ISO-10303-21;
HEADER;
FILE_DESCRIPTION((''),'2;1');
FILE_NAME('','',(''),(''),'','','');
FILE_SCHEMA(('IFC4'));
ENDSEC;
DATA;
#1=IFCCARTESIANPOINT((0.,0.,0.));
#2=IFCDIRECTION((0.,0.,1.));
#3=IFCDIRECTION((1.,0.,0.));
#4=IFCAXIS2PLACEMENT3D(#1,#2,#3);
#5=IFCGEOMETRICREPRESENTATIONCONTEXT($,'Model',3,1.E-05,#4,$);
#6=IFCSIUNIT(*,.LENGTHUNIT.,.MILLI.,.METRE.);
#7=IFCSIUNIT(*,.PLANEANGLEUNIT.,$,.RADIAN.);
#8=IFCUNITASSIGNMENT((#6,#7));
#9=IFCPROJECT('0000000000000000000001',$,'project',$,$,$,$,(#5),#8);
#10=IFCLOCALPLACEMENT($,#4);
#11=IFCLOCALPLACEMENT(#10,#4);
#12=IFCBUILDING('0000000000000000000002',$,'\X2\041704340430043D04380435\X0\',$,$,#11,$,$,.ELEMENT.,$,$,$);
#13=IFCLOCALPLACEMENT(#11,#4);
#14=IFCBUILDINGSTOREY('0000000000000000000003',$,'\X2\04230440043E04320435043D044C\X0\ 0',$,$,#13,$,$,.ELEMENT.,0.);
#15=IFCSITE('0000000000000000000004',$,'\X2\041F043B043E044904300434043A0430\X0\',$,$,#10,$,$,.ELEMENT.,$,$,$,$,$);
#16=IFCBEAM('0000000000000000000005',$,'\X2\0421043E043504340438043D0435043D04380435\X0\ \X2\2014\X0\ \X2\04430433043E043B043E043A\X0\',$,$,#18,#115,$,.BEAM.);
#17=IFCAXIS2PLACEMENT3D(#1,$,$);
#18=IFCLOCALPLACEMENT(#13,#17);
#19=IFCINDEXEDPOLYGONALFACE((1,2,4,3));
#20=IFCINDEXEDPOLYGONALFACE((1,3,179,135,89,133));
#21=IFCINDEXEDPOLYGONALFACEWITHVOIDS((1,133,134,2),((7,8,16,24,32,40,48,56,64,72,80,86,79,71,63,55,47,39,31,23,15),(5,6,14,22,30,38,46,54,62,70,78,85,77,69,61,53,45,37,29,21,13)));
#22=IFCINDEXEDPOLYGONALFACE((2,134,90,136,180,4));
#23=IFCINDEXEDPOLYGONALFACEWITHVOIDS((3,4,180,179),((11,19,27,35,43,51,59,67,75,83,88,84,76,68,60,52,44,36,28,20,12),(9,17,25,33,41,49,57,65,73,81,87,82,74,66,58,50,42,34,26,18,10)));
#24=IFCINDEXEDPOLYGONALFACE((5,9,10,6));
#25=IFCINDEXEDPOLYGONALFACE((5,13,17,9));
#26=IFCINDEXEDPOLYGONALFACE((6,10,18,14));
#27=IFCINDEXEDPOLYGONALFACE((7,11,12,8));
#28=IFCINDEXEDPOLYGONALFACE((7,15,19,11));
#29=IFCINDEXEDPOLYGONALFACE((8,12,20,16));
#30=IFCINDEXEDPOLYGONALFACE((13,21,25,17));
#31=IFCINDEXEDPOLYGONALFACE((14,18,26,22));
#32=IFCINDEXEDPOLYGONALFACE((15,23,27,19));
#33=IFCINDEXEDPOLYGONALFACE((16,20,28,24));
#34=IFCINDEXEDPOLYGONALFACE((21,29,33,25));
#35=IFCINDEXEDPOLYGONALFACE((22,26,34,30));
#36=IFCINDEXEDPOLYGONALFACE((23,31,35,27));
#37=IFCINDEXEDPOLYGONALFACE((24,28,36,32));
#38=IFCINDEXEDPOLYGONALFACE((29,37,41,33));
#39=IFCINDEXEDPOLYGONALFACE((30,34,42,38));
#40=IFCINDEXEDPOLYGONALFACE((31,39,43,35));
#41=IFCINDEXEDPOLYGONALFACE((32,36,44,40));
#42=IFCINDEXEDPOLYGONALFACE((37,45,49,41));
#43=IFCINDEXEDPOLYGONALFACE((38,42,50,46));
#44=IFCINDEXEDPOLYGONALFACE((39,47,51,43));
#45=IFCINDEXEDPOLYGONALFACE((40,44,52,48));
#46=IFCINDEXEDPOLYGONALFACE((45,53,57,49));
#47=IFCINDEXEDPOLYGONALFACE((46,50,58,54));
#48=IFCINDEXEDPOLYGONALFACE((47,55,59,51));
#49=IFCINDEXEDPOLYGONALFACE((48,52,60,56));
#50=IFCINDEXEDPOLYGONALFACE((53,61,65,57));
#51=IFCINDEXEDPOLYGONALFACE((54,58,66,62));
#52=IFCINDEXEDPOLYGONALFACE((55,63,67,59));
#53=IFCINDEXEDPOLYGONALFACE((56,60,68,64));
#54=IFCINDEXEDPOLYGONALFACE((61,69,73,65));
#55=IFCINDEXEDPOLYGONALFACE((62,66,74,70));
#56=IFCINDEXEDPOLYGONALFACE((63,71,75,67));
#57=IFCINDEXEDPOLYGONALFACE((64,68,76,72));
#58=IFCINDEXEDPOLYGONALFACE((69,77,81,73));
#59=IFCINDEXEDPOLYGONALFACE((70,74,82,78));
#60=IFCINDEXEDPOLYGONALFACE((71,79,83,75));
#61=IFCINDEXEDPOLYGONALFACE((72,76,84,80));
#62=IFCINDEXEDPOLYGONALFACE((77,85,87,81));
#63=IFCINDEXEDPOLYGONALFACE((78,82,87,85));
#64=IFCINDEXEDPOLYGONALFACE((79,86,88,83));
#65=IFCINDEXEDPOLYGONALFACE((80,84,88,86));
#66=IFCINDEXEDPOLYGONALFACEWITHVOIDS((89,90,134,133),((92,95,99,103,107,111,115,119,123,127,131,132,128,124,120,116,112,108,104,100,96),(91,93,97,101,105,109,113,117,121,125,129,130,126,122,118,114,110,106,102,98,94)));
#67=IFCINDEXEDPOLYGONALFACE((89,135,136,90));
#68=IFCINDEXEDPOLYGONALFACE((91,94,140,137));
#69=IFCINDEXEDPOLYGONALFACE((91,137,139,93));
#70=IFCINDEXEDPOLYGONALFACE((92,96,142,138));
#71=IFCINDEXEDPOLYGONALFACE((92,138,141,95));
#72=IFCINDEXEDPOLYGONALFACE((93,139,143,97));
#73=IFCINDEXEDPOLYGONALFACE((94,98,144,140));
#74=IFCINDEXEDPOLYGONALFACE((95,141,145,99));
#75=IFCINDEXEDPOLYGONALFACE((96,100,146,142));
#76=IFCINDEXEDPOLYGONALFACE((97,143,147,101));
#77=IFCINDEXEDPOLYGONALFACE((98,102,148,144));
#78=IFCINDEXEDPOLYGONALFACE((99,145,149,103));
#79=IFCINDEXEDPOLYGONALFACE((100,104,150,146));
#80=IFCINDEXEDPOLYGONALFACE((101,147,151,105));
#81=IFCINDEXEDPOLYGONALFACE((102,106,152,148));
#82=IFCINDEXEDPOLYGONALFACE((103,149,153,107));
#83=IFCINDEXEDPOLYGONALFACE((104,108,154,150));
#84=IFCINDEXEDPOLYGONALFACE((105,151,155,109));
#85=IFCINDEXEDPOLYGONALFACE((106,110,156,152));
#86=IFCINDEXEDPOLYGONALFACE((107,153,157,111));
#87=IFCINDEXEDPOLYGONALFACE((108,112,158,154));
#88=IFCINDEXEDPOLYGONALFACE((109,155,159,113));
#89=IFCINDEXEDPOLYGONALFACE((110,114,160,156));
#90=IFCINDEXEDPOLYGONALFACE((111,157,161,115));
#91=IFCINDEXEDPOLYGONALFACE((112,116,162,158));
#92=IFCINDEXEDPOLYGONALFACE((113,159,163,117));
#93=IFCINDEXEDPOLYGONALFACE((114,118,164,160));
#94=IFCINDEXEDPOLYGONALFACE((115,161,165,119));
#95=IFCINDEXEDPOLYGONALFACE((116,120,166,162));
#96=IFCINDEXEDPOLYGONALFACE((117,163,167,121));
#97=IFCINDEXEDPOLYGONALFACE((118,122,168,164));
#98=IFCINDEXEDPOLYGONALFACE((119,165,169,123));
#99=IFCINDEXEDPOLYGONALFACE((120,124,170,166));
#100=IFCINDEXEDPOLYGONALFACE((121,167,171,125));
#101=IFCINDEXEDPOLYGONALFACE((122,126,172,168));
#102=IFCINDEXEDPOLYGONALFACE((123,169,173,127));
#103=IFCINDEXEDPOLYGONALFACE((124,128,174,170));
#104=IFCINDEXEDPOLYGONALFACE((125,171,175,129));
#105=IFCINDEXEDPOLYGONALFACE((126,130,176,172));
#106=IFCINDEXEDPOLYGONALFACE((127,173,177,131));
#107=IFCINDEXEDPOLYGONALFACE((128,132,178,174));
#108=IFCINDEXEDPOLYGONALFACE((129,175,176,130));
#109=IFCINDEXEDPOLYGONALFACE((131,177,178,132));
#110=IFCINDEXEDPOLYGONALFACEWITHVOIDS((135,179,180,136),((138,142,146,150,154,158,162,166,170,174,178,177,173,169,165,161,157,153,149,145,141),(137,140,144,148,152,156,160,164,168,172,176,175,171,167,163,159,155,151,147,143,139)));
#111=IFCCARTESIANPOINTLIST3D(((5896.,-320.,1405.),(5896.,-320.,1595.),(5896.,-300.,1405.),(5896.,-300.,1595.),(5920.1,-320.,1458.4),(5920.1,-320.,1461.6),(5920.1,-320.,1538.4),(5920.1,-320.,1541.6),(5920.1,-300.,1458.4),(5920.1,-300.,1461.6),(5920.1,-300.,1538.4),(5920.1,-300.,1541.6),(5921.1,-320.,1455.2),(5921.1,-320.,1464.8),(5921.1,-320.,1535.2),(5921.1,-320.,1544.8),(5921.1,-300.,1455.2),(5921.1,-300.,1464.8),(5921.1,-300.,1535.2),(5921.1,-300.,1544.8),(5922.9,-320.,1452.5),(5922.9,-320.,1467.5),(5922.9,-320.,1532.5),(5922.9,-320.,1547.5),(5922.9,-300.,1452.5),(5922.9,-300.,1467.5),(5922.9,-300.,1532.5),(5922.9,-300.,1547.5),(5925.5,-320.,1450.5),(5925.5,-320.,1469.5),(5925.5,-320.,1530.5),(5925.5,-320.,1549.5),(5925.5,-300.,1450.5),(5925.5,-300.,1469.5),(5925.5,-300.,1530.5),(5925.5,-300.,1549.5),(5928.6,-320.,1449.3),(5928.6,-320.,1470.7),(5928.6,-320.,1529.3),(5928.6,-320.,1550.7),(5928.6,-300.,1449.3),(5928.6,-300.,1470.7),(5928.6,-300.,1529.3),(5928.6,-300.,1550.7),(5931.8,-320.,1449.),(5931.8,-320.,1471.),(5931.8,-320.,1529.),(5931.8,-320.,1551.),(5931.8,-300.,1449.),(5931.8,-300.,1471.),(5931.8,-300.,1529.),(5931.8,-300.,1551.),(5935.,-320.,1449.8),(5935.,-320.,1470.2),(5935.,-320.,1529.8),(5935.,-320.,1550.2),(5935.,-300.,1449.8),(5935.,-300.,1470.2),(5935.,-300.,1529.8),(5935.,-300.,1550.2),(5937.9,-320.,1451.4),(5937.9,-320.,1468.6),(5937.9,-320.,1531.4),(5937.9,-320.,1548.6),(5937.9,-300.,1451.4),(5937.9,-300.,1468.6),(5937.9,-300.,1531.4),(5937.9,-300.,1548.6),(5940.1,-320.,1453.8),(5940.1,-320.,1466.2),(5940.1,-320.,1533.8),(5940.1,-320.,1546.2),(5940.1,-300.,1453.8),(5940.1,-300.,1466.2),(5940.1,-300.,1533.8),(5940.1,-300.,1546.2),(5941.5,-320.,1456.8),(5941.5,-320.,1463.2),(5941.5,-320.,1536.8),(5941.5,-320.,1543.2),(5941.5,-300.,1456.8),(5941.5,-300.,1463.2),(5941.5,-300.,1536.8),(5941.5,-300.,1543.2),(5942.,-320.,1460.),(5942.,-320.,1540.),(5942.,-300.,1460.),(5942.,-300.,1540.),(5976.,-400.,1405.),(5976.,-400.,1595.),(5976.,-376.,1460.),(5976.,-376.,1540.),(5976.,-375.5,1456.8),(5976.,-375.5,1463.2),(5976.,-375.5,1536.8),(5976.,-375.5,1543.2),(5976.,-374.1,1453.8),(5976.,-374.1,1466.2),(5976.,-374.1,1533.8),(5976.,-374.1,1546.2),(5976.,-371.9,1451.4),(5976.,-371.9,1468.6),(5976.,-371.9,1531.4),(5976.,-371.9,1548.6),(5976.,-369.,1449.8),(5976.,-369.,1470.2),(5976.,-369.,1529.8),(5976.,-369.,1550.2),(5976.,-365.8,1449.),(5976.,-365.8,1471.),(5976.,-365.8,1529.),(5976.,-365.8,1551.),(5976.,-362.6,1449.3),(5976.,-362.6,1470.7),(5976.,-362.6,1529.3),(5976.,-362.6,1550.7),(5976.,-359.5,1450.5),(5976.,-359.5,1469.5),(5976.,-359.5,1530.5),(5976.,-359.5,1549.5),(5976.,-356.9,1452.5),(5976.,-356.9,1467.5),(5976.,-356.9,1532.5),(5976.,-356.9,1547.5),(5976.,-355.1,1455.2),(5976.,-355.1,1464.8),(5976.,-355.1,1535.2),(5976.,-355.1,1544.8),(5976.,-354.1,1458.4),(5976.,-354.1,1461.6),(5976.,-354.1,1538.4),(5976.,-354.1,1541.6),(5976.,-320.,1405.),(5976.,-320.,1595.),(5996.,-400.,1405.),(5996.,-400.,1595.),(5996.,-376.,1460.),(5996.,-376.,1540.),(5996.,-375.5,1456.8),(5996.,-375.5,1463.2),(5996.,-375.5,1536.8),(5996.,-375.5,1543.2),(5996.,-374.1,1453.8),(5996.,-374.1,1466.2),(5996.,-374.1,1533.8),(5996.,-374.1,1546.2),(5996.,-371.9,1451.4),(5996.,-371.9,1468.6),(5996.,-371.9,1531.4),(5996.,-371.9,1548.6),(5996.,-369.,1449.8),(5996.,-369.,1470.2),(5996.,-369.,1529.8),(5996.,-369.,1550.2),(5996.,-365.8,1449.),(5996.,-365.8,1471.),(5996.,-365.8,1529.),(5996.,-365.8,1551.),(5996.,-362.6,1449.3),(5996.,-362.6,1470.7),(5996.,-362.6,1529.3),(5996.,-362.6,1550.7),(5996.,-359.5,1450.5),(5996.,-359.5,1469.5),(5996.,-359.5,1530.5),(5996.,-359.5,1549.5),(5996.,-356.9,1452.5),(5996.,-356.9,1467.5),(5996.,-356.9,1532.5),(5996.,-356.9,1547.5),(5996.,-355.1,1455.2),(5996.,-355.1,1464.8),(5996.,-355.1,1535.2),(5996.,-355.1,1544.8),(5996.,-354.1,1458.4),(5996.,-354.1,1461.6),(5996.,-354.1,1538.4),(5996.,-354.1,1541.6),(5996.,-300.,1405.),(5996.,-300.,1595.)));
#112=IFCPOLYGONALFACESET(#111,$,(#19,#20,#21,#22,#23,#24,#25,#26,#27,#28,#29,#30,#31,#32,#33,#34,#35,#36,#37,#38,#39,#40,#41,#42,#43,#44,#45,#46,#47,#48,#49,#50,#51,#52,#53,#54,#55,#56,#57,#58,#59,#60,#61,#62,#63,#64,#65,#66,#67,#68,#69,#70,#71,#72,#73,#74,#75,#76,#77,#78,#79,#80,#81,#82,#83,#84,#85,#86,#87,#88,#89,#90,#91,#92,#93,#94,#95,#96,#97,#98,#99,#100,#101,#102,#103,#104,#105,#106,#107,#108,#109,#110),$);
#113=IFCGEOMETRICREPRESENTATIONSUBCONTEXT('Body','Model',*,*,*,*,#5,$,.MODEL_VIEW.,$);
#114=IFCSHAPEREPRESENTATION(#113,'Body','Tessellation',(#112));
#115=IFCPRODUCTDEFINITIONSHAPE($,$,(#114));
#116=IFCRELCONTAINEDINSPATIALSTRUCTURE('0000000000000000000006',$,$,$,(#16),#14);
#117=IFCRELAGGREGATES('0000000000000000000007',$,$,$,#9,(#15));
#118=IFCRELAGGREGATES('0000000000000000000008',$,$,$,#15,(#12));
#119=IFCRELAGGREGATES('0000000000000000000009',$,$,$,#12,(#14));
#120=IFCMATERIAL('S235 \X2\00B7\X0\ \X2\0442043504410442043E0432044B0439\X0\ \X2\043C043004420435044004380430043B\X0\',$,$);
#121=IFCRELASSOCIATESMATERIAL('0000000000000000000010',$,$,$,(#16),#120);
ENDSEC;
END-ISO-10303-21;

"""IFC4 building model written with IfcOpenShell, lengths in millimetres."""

from ifc_helpers import new_model, si_unit, frame, origin_with_axes, place, context, subcontext, project, spatial, circle, l_section, extrude, material, element, save


model = new_model("IFC4")

# Units and contexts
model_context = context("Model", 3, precision=1e-05, world=origin_with_axes())
body_context = subcontext(model_context, "Body", "Model", "MODEL_VIEW")
ifc_project = project(units=[si_unit("LENGTHUNIT", "METRE", prefix="MILLI"), si_unit("PLANEANGLEUNIT", "RADIAN")], contexts=[model_context])

# Site, building, storey
site_placement = place(None, origin_with_axes())
site = spatial("IfcSite", under=ifc_project, at=site_placement, Name="Площадка", CompositionType="ELEMENT")
building_placement = place(site_placement, origin_with_axes())
building = spatial("IfcBuilding", under=site, at=building_placement, Name="Здание", CompositionType="ELEMENT")
storey_placement = place(building_placement, origin_with_axes())
storey = spatial("IfcBuildingStorey", under=building, at=storey_placement, Name="Уровень 0", CompositionType="ELEMENT", Elevation=0.0)

# Shared definitions
ifc_material = material(Name="S235 · тестовый материал")

# Beam, openings
beam_1_placement = place(storey_placement, frame((5946.0, -350.0, 1595.0), z_axis=(0.0, 0.0, -1.0), x_axis=(0.0, -1.0, 0.0)))
beam_1 = element("IfcBeam", 1, at=beam_1_placement, inside=storey, material=ifc_material, Name="Соединение — уголок", PredefinedType="BEAM", context=body_context, shape_type="SweptSolid", body=[
    extrude(l_section(Depth=100.0, Width=100.0, Thickness=20.0), origin_with_axes(), (0.0, 0.0, 1.0), 190.0),
])
opening_1_placement = place(beam_1_placement, frame((15.0, -29.0, 55.0), z_axis=(0.0, -1.0, 0.0), x_axis=(1.0, 0.0, 0.0)))
element("IfcOpeningElement", 2, at=opening_1_placement, cuts=beam_1, PredefinedType="OPENING", context=body_context, shape_type="SweptSolid", body=[
    extrude(circle(Radius=11.0), origin_with_axes(), (0.0, 0.0, 1.0), 30.0),
])
opening_2_placement = place(beam_1_placement, frame((15.0, -29.0, 135.0), z_axis=(0.0, -1.0, 0.0), x_axis=(1.0, 0.0, 0.0)))
element("IfcOpeningElement", 3, at=opening_2_placement, cuts=beam_1, PredefinedType="OPENING", context=body_context, shape_type="SweptSolid", body=[
    extrude(circle(Radius=11.0), origin_with_axes(), (0.0, 0.0, 1.0), 30.0),
])
opening_3_placement = place(beam_1_placement, frame((-29.0, 15.0, 55.0), z_axis=(-1.0, 0.0, 0.0), x_axis=(0.0, -1.0, 0.0)))
element("IfcOpeningElement", 4, at=opening_3_placement, cuts=beam_1, PredefinedType="OPENING", context=body_context, shape_type="SweptSolid", body=[
    extrude(circle(Radius=11.0), origin_with_axes(), (0.0, 0.0, 1.0), 42.0),
])
opening_4_placement = place(beam_1_placement, frame((-29.0, 15.0, 135.0), z_axis=(-1.0, 0.0, 0.0), x_axis=(0.0, -1.0, 0.0)))
element("IfcOpeningElement", 5, at=opening_4_placement, cuts=beam_1, PredefinedType="OPENING", context=body_context, shape_type="SweptSolid", body=[
    extrude(circle(Radius=11.0), origin_with_axes(), (0.0, 0.0, 1.0), 42.0),
])

save(model, "model.ifc")
